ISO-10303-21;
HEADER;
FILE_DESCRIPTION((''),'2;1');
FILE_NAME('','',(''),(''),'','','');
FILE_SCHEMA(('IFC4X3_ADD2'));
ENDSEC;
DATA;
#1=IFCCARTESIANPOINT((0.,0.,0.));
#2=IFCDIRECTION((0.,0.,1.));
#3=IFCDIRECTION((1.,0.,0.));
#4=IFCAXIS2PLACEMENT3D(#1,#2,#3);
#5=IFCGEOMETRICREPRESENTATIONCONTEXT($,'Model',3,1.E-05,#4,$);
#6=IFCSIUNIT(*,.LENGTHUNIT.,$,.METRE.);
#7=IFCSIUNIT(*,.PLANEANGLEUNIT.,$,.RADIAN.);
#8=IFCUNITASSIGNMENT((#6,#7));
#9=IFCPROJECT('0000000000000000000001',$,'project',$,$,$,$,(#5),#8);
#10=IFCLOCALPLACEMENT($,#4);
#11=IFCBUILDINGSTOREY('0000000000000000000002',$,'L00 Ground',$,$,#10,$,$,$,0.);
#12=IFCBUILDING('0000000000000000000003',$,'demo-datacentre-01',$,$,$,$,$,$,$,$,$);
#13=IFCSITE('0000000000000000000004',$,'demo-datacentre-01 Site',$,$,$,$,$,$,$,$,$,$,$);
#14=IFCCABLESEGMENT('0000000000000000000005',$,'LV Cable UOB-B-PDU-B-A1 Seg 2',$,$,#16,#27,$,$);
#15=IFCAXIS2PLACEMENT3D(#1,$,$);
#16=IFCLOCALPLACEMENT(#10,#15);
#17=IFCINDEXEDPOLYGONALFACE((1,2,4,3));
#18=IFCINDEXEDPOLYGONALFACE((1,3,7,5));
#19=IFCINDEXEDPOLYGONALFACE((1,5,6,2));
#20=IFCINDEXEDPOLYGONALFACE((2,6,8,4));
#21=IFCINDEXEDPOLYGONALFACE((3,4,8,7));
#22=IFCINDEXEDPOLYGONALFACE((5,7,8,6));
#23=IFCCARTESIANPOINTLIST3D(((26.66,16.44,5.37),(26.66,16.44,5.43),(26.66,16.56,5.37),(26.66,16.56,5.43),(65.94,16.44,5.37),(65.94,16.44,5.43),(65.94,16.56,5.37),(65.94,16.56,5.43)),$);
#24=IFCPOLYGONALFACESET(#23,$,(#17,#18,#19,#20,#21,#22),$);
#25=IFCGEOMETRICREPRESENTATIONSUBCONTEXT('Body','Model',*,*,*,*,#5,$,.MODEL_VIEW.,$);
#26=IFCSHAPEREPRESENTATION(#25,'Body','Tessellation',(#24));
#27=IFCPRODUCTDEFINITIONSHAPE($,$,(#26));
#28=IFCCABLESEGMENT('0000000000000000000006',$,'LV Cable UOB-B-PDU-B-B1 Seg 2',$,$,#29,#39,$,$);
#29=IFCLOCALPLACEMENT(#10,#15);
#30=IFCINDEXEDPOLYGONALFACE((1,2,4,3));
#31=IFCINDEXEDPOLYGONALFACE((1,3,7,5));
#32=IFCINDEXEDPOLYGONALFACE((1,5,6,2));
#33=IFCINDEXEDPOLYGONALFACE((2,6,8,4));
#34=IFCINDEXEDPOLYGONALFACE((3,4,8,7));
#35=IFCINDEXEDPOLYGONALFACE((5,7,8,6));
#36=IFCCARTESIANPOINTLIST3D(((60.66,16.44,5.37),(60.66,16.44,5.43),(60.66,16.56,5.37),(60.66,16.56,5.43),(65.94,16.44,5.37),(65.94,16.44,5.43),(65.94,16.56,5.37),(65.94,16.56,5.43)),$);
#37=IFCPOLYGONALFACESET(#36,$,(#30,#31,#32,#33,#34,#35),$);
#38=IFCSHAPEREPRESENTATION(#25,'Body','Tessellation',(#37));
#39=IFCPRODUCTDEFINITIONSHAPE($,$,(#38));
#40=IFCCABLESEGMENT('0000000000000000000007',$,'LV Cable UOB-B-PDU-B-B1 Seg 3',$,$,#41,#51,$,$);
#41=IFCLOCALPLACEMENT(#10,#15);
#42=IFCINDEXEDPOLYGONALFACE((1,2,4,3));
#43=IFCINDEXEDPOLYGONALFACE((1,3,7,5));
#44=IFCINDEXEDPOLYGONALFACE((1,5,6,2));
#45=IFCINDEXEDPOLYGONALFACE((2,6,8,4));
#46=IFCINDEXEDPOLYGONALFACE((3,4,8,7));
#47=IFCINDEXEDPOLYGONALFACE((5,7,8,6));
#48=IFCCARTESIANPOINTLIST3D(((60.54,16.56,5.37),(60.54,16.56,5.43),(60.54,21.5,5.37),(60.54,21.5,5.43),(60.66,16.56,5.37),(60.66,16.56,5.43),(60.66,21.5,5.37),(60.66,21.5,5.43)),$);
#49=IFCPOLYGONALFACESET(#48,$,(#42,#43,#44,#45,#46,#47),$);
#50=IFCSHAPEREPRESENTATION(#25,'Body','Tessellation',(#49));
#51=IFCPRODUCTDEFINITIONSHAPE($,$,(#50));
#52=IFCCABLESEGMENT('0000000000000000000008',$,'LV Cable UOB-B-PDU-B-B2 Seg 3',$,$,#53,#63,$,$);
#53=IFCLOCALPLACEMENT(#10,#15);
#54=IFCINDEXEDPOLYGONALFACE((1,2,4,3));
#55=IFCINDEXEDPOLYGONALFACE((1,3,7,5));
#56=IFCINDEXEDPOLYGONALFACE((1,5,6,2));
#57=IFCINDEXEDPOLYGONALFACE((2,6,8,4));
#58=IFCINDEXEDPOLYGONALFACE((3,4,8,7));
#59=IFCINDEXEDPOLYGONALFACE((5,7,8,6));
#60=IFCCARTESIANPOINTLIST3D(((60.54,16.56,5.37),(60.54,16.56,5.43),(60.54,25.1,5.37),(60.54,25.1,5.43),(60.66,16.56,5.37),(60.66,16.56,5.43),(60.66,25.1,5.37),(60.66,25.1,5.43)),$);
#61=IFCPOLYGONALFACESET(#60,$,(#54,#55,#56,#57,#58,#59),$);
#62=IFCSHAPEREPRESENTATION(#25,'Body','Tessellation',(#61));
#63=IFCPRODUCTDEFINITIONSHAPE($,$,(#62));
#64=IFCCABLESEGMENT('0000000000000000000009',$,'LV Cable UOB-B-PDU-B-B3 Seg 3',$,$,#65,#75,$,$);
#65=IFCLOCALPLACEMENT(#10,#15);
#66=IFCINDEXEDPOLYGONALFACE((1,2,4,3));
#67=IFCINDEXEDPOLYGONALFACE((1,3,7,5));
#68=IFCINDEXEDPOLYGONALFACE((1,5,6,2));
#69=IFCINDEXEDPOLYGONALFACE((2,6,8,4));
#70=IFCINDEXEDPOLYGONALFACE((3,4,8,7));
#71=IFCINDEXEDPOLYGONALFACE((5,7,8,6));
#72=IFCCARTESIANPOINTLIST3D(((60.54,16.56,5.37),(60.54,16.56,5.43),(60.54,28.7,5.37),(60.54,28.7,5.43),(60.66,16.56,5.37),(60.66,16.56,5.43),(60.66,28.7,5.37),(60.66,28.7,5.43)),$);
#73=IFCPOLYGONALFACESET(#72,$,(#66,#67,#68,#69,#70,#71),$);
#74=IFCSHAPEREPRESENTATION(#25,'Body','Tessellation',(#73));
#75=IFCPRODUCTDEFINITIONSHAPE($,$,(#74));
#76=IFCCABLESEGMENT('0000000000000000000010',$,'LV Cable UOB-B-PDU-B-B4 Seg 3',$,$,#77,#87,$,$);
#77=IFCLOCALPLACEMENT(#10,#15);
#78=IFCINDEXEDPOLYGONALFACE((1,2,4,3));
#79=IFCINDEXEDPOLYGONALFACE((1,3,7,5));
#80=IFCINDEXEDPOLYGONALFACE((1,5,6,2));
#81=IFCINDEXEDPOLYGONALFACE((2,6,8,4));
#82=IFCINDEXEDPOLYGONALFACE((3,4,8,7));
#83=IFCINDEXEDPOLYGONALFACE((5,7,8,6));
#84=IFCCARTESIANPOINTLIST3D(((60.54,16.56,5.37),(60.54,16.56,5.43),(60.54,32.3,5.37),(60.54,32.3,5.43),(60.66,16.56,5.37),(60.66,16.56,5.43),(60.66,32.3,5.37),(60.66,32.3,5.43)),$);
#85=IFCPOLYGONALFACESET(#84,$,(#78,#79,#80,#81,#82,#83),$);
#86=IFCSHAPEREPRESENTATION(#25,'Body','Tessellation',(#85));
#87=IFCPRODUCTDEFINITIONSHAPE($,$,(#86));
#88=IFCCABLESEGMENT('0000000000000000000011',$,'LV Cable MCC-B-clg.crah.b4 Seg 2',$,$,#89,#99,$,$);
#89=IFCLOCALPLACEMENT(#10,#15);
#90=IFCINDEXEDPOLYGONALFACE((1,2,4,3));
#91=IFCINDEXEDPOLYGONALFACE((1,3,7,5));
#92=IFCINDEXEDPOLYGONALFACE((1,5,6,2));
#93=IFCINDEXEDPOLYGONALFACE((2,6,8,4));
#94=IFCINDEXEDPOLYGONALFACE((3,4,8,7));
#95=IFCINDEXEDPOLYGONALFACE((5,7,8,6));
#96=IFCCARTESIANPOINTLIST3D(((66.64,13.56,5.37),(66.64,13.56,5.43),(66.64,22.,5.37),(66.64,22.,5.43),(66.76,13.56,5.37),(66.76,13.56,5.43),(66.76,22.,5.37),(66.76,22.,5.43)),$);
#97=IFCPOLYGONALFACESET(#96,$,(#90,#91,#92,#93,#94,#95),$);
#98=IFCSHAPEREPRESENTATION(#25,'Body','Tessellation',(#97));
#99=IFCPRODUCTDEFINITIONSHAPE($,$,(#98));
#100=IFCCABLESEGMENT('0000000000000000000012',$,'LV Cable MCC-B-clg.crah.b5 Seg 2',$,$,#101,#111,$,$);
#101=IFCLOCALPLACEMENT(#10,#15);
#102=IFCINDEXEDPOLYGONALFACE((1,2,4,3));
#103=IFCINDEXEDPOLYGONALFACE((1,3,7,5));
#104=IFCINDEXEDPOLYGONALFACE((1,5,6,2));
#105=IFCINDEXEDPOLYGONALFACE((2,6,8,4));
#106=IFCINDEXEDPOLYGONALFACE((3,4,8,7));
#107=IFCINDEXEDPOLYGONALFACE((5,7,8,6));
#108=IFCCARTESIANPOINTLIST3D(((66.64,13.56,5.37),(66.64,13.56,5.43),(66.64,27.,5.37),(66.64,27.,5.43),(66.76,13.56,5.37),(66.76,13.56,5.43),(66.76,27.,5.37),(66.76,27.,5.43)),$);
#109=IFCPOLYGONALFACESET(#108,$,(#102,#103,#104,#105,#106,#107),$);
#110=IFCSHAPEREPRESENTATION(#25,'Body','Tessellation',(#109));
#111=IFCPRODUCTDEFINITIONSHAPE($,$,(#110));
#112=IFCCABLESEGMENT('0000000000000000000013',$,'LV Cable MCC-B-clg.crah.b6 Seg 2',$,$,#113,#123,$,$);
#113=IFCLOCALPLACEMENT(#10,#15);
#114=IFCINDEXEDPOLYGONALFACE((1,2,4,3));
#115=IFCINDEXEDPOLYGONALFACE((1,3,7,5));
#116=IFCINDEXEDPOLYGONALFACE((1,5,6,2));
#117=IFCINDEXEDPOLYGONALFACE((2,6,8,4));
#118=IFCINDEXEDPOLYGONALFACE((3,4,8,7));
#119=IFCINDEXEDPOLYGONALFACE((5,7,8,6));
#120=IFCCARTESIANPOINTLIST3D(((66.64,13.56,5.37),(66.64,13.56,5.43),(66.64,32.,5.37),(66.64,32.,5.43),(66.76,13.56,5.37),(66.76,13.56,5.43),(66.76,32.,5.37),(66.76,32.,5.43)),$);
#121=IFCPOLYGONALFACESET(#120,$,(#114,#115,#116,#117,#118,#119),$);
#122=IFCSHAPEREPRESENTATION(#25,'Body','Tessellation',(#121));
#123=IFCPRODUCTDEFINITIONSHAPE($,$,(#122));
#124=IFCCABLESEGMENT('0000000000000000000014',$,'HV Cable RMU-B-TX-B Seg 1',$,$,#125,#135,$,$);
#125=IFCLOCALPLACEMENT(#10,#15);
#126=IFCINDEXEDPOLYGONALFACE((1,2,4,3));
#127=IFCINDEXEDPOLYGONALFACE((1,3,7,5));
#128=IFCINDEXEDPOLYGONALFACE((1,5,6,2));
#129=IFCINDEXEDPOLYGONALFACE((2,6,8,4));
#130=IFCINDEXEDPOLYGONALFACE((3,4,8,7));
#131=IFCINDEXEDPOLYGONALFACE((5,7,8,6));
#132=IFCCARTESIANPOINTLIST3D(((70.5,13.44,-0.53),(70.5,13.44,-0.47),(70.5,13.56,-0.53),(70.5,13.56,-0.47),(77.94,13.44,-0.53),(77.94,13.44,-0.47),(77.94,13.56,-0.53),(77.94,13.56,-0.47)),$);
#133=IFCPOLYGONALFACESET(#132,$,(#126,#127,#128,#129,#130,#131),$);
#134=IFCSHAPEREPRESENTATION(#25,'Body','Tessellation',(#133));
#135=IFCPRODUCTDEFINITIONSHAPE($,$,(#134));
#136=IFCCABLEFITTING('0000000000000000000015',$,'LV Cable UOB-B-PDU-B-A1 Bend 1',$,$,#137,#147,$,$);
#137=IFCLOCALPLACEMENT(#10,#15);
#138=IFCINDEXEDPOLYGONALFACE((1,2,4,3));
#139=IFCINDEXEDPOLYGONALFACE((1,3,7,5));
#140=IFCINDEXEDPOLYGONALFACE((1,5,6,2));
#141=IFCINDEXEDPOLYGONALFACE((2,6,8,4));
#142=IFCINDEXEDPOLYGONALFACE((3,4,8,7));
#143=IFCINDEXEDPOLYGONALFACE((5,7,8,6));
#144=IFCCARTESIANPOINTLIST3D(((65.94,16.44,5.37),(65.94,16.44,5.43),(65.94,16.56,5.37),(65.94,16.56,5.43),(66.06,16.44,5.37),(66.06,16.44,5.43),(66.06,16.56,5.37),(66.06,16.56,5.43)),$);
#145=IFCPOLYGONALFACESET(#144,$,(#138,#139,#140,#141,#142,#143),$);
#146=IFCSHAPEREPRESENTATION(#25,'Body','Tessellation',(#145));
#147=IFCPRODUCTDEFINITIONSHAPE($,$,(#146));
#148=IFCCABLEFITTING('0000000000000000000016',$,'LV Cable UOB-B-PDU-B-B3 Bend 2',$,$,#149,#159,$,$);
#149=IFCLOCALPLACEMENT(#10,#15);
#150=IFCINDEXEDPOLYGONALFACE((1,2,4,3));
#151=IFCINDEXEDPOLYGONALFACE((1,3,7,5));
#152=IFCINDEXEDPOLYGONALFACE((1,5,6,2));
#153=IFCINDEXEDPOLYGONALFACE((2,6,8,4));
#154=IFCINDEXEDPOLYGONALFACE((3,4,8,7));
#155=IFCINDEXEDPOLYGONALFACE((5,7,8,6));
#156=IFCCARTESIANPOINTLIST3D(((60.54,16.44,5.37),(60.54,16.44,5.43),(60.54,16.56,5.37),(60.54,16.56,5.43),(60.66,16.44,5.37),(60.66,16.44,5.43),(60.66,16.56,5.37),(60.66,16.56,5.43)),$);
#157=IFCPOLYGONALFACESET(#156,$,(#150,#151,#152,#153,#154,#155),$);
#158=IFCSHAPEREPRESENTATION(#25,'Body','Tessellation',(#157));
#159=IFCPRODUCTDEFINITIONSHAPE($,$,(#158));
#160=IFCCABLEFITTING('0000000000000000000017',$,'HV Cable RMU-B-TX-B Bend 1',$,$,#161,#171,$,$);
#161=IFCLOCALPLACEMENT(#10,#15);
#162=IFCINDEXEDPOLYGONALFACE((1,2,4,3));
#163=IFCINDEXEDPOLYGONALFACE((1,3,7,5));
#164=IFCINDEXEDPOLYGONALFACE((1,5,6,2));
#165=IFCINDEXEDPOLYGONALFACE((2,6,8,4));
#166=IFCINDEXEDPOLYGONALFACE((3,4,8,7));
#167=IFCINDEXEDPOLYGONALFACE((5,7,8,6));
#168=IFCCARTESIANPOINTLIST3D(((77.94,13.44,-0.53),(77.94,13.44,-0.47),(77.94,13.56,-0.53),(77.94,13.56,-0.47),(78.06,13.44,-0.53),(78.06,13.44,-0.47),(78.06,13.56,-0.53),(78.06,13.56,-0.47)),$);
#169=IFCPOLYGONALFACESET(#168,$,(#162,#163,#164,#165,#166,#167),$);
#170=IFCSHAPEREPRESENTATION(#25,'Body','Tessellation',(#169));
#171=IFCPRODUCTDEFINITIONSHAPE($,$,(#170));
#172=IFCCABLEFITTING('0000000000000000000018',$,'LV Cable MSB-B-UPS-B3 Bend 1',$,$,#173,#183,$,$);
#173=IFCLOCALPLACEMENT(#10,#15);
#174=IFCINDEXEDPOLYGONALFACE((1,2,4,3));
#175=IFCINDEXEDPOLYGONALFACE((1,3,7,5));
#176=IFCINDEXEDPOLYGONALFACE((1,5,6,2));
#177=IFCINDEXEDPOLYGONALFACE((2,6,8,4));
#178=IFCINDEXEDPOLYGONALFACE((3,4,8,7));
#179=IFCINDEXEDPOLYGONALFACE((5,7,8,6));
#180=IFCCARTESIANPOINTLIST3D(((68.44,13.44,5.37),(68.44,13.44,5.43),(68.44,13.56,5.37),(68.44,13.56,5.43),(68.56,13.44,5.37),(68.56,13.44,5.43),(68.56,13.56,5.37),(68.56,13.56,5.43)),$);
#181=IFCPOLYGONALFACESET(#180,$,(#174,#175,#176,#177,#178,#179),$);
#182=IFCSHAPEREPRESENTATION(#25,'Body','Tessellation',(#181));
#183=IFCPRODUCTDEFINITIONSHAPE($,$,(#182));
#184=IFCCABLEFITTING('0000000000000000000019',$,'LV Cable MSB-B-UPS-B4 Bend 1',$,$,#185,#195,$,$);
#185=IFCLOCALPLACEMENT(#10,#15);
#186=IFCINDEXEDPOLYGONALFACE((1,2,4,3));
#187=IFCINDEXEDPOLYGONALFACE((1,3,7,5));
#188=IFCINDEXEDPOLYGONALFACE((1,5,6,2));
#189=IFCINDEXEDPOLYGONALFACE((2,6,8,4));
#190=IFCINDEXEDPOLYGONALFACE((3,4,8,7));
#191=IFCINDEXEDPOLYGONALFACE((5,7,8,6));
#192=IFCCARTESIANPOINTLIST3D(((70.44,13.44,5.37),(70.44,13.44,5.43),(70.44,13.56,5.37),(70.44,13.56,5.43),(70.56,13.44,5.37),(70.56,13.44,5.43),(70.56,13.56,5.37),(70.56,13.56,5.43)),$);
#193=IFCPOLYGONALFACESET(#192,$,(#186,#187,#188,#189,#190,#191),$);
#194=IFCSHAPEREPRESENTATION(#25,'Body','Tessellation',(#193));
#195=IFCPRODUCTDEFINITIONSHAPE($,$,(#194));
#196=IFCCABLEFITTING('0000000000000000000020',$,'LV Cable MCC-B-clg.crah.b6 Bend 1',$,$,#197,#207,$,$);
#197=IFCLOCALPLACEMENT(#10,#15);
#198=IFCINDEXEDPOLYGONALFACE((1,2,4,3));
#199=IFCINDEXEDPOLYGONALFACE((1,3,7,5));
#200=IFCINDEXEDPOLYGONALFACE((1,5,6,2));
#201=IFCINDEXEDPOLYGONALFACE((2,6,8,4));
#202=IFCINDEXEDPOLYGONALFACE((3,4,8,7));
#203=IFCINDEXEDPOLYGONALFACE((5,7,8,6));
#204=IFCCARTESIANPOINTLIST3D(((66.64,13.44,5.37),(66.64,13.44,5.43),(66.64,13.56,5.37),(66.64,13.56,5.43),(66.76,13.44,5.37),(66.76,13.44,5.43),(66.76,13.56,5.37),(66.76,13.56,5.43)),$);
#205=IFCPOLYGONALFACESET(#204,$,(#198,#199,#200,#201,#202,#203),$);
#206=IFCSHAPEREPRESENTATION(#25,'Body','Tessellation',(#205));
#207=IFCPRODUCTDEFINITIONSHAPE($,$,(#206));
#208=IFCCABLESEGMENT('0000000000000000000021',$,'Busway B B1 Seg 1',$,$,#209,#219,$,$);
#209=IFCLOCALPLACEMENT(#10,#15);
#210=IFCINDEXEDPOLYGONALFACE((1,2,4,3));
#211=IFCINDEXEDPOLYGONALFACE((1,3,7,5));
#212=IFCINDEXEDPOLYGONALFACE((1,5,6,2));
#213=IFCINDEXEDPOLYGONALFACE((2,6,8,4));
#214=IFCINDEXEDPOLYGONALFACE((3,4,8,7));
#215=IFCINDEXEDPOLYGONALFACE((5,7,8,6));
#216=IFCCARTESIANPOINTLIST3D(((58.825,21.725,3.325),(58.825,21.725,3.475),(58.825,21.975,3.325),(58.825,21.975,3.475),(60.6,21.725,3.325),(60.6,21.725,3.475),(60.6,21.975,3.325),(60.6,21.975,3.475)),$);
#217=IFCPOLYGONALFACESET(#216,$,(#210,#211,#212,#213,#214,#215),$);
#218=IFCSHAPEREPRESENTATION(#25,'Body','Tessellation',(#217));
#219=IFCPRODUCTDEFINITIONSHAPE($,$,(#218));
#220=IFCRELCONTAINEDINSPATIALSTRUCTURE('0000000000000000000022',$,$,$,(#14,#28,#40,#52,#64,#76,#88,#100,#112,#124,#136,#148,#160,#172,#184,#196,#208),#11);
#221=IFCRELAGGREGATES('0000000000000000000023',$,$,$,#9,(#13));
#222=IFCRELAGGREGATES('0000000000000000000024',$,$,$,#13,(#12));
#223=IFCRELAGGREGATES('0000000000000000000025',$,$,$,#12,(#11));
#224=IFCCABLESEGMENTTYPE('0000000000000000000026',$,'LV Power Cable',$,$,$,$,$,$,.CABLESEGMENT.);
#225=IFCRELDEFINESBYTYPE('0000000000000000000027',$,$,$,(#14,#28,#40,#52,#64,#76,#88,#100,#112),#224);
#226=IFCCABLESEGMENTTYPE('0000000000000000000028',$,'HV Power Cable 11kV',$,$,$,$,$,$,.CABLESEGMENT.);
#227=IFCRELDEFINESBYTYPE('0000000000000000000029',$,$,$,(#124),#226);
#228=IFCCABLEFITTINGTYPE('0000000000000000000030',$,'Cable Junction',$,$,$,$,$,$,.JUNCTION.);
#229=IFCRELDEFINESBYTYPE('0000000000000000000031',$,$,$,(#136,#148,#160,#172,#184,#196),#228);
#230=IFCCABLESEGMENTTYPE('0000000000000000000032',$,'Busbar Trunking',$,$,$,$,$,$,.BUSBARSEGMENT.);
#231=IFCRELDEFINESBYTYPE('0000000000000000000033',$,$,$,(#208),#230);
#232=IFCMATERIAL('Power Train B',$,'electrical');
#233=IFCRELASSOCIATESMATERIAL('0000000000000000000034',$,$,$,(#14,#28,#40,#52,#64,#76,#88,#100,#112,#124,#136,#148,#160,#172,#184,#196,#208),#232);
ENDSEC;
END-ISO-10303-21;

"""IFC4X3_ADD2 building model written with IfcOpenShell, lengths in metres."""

from ifc_helpers import new_model, si_unit, frame, origin_with_axes, place, context, subcontext, project, spatial, rectangle, extrude, material, type_object, element, save


model = new_model("IFC4X3_ADD2")

# Units and contexts
model_context = context("Model", 3, precision=1e-05, world=origin_with_axes())
body_context = subcontext(model_context, "Body", "Model", "MODEL_VIEW")
ifc_project = project(units=[si_unit("LENGTHUNIT", "METRE"), si_unit("PLANEANGLEUNIT", "RADIAN")], contexts=[model_context])

# Site, building, storey
site = spatial("IfcSite", under=ifc_project, Name="demo-datacentre-01 Site")
building = spatial("IfcBuilding", under=site, Name="demo-datacentre-01")
storey_placement = place(None, origin_with_axes())
storey = spatial("IfcBuildingStorey", under=building, at=storey_placement, Name="L00 Ground", Elevation=0.0)

# Shared definitions
ifc_material = material(Name="Power Train B", Category="electrical")

# Cable segments
cable_segment_type_1 = type_object("IfcCableSegmentType", Name="LV Power Cable", PredefinedType="CABLESEGMENT")
for number, where, z_axis, x_axis, name in (
    (1, (65.94, 16.5, 5.4), (-1.0, 0.0, 0.0), (0.0, -1.0, 0.0), "LV Cable UOB-B-PDU-B-A1 Seg 2"),
):
    element("IfcCableSegment", number, at=place(storey_placement, frame(where, z_axis=z_axis, x_axis=x_axis)), inside=storey, type_object=cable_segment_type_1, material=ifc_material, Name=name, context=body_context, shape_type="SweptSolid", body=[
        extrude(rectangle(XDim=0.12, YDim=0.06), origin_with_axes(), (0.0, 0.0, 1.0), 39.28),
    ])
cable_segment_1_placement = place(storey_placement, frame((65.94, 16.5, 5.4), z_axis=(-1.0, 0.0, 0.0), x_axis=(0.0, -1.0, 0.0)))
element("IfcCableSegment", 2, at=cable_segment_1_placement, inside=storey, type_object=cable_segment_type_1, material=ifc_material, Name="LV Cable UOB-B-PDU-B-B1 Seg 2", context=body_context, shape_type="SweptSolid", body=[
    extrude(rectangle(XDim=0.12, YDim=0.06), origin_with_axes(), (0.0, 0.0, 1.0), 5.28),
])
cable_segment_2_placement = place(storey_placement, frame((60.6, 16.56, 5.4), z_axis=(0.0, 1.0, 0.0), x_axis=(-1.0, 0.0, 0.0)))
element("IfcCableSegment", 3, at=cable_segment_2_placement, inside=storey, type_object=cable_segment_type_1, material=ifc_material, Name="LV Cable UOB-B-PDU-B-B1 Seg 3", context=body_context, shape_type="SweptSolid", body=[
    extrude(rectangle(XDim=0.12, YDim=0.06), origin_with_axes(), (0.0, 0.0, 1.0), 4.94),
])
cable_segment_3_placement = place(storey_placement, frame((60.6, 16.56, 5.4), z_axis=(0.0, 1.0, 0.0), x_axis=(-1.0, 0.0, 0.0)))
element("IfcCableSegment", 4, at=cable_segment_3_placement, inside=storey, type_object=cable_segment_type_1, material=ifc_material, Name="LV Cable UOB-B-PDU-B-B2 Seg 3", context=body_context, shape_type="SweptSolid", body=[
    extrude(rectangle(XDim=0.12, YDim=0.06), origin_with_axes(), (0.0, 0.0, 1.0), 8.54),
])
cable_segment_4_placement = place(storey_placement, frame((60.6, 16.56, 5.4), z_axis=(0.0, 1.0, 0.0), x_axis=(-1.0, 0.0, 0.0)))
element("IfcCableSegment", 5, at=cable_segment_4_placement, inside=storey, type_object=cable_segment_type_1, material=ifc_material, Name="LV Cable UOB-B-PDU-B-B3 Seg 3", context=body_context, shape_type="SweptSolid", body=[
    extrude(rectangle(XDim=0.12, YDim=0.06), origin_with_axes(), (0.0, 0.0, 1.0), 12.14),
])
cable_segment_5_placement = place(storey_placement, frame((60.6, 16.56, 5.4), z_axis=(0.0, 1.0, 0.0), x_axis=(-1.0, 0.0, 0.0)))
element("IfcCableSegment", 6, at=cable_segment_5_placement, inside=storey, type_object=cable_segment_type_1, material=ifc_material, Name="LV Cable UOB-B-PDU-B-B4 Seg 3", context=body_context, shape_type="SweptSolid", body=[
    extrude(rectangle(XDim=0.12, YDim=0.06), origin_with_axes(), (0.0, 0.0, 1.0), 15.74),
])
cable_segment_6_placement = place(storey_placement, frame((66.7, 13.56, 5.4), z_axis=(0.0, 1.0, 0.0), x_axis=(-1.0, 0.0, 0.0)))
element("IfcCableSegment", 7, at=cable_segment_6_placement, inside=storey, type_object=cable_segment_type_1, material=ifc_material, Name="LV Cable MCC-B-clg.crah.b4 Seg 2", context=body_context, shape_type="SweptSolid", body=[
    extrude(rectangle(XDim=0.12, YDim=0.06), origin_with_axes(), (0.0, 0.0, 1.0), 8.44),
])
cable_segment_7_placement = place(storey_placement, frame((66.7, 13.56, 5.4), z_axis=(0.0, 1.0, 0.0), x_axis=(-1.0, 0.0, 0.0)))
element("IfcCableSegment", 8, at=cable_segment_7_placement, inside=storey, type_object=cable_segment_type_1, material=ifc_material, Name="LV Cable MCC-B-clg.crah.b5 Seg 2", context=body_context, shape_type="SweptSolid", body=[
    extrude(rectangle(XDim=0.12, YDim=0.06), origin_with_axes(), (0.0, 0.0, 1.0), 13.44),
])
cable_segment_8_placement = place(storey_placement, frame((66.7, 13.56, 5.4), z_axis=(0.0, 1.0, 0.0), x_axis=(-1.0, 0.0, 0.0)))
element("IfcCableSegment", 9, at=cable_segment_8_placement, inside=storey, type_object=cable_segment_type_1, material=ifc_material, Name="LV Cable MCC-B-clg.crah.b6 Seg 2", context=body_context, shape_type="SweptSolid", body=[
    extrude(rectangle(XDim=0.12, YDim=0.06), origin_with_axes(), (0.0, 0.0, 1.0), 18.44),
])
cable_segment_type_2 = type_object("IfcCableSegmentType", Name="HV Power Cable 11kV", PredefinedType="CABLESEGMENT")
cable_segment_9_placement = place(storey_placement, frame((70.5, 13.5, -0.5), z_axis=(1.0, 0.0, 0.0), x_axis=(0.0, 1.0, 0.0)))
element("IfcCableSegment", 10, at=cable_segment_9_placement, inside=storey, type_object=cable_segment_type_2, material=ifc_material, Name="HV Cable RMU-B-TX-B Seg 1", context=body_context, shape_type="SweptSolid", body=[
    extrude(rectangle(XDim=0.12, YDim=0.06), origin_with_axes(), (0.0, 0.0, 1.0), 7.44),
])

# Cable fittings
cable_fitting_type = type_object("IfcCableFittingType", Name="Cable Junction", PredefinedType="JUNCTION")
for number, where, z_axis, x_axis, name in (
    (11, (66.0, 16.5, 5.37), (0.0, 0.0, 1.0), (1.0, 0.0, 0.0), "LV Cable UOB-B-PDU-B-A1 Bend 1"),
    (12, (60.6, 16.5, 5.37), (0.0, 0.0, 1.0), (1.0, 0.0, 0.0), "LV Cable UOB-B-PDU-B-B3 Bend 2"),
    (13, (78.0, 13.5, -0.53), (0.0, 0.0, 1.0), (1.0, 0.0, 0.0), "HV Cable RMU-B-TX-B Bend 1"),
    (14, (68.5, 13.5, 5.37), (0.0, 0.0, 1.0), (1.0, 0.0, 0.0), "LV Cable MSB-B-UPS-B3 Bend 1"),
    (15, (70.5, 13.5, 5.37), (0.0, 0.0, 1.0), (1.0, 0.0, 0.0), "LV Cable MSB-B-UPS-B4 Bend 1"),
    (16, (66.7, 13.5, 5.37), (0.0, 0.0, 1.0), (1.0, 0.0, 0.0), "LV Cable MCC-B-clg.crah.b6 Bend 1"),
):
    element("IfcCableFitting", number, at=place(storey_placement, frame(where, z_axis=z_axis, x_axis=x_axis)), inside=storey, type_object=cable_fitting_type, material=ifc_material, Name=name, context=body_context, shape_type="SweptSolid", body=[
        extrude(rectangle(XDim=0.12, YDim=0.12), origin_with_axes(), (0.0, 0.0, 1.0), 0.06),
    ])

# Cable segment
cable_segment_type_3 = type_object("IfcCableSegmentType", Name="Busbar Trunking", PredefinedType="BUSBARSEGMENT")
for number, where, z_axis, x_axis, name in (
    (17, (60.6, 21.85, 3.4), (-1.0, 0.0, 0.0), (0.0, -1.0, 0.0), "Busway B B1 Seg 1"),
):
    element("IfcCableSegment", number, at=place(storey_placement, frame(where, z_axis=z_axis, x_axis=x_axis)), inside=storey, type_object=cable_segment_type_3, material=ifc_material, Name=name, context=body_context, shape_type="SweptSolid", body=[
        extrude(rectangle(XDim=0.25, YDim=0.15), origin_with_axes(), (0.0, 0.0, 1.0), 1.775),
    ])

save(model, "model.ifc")
